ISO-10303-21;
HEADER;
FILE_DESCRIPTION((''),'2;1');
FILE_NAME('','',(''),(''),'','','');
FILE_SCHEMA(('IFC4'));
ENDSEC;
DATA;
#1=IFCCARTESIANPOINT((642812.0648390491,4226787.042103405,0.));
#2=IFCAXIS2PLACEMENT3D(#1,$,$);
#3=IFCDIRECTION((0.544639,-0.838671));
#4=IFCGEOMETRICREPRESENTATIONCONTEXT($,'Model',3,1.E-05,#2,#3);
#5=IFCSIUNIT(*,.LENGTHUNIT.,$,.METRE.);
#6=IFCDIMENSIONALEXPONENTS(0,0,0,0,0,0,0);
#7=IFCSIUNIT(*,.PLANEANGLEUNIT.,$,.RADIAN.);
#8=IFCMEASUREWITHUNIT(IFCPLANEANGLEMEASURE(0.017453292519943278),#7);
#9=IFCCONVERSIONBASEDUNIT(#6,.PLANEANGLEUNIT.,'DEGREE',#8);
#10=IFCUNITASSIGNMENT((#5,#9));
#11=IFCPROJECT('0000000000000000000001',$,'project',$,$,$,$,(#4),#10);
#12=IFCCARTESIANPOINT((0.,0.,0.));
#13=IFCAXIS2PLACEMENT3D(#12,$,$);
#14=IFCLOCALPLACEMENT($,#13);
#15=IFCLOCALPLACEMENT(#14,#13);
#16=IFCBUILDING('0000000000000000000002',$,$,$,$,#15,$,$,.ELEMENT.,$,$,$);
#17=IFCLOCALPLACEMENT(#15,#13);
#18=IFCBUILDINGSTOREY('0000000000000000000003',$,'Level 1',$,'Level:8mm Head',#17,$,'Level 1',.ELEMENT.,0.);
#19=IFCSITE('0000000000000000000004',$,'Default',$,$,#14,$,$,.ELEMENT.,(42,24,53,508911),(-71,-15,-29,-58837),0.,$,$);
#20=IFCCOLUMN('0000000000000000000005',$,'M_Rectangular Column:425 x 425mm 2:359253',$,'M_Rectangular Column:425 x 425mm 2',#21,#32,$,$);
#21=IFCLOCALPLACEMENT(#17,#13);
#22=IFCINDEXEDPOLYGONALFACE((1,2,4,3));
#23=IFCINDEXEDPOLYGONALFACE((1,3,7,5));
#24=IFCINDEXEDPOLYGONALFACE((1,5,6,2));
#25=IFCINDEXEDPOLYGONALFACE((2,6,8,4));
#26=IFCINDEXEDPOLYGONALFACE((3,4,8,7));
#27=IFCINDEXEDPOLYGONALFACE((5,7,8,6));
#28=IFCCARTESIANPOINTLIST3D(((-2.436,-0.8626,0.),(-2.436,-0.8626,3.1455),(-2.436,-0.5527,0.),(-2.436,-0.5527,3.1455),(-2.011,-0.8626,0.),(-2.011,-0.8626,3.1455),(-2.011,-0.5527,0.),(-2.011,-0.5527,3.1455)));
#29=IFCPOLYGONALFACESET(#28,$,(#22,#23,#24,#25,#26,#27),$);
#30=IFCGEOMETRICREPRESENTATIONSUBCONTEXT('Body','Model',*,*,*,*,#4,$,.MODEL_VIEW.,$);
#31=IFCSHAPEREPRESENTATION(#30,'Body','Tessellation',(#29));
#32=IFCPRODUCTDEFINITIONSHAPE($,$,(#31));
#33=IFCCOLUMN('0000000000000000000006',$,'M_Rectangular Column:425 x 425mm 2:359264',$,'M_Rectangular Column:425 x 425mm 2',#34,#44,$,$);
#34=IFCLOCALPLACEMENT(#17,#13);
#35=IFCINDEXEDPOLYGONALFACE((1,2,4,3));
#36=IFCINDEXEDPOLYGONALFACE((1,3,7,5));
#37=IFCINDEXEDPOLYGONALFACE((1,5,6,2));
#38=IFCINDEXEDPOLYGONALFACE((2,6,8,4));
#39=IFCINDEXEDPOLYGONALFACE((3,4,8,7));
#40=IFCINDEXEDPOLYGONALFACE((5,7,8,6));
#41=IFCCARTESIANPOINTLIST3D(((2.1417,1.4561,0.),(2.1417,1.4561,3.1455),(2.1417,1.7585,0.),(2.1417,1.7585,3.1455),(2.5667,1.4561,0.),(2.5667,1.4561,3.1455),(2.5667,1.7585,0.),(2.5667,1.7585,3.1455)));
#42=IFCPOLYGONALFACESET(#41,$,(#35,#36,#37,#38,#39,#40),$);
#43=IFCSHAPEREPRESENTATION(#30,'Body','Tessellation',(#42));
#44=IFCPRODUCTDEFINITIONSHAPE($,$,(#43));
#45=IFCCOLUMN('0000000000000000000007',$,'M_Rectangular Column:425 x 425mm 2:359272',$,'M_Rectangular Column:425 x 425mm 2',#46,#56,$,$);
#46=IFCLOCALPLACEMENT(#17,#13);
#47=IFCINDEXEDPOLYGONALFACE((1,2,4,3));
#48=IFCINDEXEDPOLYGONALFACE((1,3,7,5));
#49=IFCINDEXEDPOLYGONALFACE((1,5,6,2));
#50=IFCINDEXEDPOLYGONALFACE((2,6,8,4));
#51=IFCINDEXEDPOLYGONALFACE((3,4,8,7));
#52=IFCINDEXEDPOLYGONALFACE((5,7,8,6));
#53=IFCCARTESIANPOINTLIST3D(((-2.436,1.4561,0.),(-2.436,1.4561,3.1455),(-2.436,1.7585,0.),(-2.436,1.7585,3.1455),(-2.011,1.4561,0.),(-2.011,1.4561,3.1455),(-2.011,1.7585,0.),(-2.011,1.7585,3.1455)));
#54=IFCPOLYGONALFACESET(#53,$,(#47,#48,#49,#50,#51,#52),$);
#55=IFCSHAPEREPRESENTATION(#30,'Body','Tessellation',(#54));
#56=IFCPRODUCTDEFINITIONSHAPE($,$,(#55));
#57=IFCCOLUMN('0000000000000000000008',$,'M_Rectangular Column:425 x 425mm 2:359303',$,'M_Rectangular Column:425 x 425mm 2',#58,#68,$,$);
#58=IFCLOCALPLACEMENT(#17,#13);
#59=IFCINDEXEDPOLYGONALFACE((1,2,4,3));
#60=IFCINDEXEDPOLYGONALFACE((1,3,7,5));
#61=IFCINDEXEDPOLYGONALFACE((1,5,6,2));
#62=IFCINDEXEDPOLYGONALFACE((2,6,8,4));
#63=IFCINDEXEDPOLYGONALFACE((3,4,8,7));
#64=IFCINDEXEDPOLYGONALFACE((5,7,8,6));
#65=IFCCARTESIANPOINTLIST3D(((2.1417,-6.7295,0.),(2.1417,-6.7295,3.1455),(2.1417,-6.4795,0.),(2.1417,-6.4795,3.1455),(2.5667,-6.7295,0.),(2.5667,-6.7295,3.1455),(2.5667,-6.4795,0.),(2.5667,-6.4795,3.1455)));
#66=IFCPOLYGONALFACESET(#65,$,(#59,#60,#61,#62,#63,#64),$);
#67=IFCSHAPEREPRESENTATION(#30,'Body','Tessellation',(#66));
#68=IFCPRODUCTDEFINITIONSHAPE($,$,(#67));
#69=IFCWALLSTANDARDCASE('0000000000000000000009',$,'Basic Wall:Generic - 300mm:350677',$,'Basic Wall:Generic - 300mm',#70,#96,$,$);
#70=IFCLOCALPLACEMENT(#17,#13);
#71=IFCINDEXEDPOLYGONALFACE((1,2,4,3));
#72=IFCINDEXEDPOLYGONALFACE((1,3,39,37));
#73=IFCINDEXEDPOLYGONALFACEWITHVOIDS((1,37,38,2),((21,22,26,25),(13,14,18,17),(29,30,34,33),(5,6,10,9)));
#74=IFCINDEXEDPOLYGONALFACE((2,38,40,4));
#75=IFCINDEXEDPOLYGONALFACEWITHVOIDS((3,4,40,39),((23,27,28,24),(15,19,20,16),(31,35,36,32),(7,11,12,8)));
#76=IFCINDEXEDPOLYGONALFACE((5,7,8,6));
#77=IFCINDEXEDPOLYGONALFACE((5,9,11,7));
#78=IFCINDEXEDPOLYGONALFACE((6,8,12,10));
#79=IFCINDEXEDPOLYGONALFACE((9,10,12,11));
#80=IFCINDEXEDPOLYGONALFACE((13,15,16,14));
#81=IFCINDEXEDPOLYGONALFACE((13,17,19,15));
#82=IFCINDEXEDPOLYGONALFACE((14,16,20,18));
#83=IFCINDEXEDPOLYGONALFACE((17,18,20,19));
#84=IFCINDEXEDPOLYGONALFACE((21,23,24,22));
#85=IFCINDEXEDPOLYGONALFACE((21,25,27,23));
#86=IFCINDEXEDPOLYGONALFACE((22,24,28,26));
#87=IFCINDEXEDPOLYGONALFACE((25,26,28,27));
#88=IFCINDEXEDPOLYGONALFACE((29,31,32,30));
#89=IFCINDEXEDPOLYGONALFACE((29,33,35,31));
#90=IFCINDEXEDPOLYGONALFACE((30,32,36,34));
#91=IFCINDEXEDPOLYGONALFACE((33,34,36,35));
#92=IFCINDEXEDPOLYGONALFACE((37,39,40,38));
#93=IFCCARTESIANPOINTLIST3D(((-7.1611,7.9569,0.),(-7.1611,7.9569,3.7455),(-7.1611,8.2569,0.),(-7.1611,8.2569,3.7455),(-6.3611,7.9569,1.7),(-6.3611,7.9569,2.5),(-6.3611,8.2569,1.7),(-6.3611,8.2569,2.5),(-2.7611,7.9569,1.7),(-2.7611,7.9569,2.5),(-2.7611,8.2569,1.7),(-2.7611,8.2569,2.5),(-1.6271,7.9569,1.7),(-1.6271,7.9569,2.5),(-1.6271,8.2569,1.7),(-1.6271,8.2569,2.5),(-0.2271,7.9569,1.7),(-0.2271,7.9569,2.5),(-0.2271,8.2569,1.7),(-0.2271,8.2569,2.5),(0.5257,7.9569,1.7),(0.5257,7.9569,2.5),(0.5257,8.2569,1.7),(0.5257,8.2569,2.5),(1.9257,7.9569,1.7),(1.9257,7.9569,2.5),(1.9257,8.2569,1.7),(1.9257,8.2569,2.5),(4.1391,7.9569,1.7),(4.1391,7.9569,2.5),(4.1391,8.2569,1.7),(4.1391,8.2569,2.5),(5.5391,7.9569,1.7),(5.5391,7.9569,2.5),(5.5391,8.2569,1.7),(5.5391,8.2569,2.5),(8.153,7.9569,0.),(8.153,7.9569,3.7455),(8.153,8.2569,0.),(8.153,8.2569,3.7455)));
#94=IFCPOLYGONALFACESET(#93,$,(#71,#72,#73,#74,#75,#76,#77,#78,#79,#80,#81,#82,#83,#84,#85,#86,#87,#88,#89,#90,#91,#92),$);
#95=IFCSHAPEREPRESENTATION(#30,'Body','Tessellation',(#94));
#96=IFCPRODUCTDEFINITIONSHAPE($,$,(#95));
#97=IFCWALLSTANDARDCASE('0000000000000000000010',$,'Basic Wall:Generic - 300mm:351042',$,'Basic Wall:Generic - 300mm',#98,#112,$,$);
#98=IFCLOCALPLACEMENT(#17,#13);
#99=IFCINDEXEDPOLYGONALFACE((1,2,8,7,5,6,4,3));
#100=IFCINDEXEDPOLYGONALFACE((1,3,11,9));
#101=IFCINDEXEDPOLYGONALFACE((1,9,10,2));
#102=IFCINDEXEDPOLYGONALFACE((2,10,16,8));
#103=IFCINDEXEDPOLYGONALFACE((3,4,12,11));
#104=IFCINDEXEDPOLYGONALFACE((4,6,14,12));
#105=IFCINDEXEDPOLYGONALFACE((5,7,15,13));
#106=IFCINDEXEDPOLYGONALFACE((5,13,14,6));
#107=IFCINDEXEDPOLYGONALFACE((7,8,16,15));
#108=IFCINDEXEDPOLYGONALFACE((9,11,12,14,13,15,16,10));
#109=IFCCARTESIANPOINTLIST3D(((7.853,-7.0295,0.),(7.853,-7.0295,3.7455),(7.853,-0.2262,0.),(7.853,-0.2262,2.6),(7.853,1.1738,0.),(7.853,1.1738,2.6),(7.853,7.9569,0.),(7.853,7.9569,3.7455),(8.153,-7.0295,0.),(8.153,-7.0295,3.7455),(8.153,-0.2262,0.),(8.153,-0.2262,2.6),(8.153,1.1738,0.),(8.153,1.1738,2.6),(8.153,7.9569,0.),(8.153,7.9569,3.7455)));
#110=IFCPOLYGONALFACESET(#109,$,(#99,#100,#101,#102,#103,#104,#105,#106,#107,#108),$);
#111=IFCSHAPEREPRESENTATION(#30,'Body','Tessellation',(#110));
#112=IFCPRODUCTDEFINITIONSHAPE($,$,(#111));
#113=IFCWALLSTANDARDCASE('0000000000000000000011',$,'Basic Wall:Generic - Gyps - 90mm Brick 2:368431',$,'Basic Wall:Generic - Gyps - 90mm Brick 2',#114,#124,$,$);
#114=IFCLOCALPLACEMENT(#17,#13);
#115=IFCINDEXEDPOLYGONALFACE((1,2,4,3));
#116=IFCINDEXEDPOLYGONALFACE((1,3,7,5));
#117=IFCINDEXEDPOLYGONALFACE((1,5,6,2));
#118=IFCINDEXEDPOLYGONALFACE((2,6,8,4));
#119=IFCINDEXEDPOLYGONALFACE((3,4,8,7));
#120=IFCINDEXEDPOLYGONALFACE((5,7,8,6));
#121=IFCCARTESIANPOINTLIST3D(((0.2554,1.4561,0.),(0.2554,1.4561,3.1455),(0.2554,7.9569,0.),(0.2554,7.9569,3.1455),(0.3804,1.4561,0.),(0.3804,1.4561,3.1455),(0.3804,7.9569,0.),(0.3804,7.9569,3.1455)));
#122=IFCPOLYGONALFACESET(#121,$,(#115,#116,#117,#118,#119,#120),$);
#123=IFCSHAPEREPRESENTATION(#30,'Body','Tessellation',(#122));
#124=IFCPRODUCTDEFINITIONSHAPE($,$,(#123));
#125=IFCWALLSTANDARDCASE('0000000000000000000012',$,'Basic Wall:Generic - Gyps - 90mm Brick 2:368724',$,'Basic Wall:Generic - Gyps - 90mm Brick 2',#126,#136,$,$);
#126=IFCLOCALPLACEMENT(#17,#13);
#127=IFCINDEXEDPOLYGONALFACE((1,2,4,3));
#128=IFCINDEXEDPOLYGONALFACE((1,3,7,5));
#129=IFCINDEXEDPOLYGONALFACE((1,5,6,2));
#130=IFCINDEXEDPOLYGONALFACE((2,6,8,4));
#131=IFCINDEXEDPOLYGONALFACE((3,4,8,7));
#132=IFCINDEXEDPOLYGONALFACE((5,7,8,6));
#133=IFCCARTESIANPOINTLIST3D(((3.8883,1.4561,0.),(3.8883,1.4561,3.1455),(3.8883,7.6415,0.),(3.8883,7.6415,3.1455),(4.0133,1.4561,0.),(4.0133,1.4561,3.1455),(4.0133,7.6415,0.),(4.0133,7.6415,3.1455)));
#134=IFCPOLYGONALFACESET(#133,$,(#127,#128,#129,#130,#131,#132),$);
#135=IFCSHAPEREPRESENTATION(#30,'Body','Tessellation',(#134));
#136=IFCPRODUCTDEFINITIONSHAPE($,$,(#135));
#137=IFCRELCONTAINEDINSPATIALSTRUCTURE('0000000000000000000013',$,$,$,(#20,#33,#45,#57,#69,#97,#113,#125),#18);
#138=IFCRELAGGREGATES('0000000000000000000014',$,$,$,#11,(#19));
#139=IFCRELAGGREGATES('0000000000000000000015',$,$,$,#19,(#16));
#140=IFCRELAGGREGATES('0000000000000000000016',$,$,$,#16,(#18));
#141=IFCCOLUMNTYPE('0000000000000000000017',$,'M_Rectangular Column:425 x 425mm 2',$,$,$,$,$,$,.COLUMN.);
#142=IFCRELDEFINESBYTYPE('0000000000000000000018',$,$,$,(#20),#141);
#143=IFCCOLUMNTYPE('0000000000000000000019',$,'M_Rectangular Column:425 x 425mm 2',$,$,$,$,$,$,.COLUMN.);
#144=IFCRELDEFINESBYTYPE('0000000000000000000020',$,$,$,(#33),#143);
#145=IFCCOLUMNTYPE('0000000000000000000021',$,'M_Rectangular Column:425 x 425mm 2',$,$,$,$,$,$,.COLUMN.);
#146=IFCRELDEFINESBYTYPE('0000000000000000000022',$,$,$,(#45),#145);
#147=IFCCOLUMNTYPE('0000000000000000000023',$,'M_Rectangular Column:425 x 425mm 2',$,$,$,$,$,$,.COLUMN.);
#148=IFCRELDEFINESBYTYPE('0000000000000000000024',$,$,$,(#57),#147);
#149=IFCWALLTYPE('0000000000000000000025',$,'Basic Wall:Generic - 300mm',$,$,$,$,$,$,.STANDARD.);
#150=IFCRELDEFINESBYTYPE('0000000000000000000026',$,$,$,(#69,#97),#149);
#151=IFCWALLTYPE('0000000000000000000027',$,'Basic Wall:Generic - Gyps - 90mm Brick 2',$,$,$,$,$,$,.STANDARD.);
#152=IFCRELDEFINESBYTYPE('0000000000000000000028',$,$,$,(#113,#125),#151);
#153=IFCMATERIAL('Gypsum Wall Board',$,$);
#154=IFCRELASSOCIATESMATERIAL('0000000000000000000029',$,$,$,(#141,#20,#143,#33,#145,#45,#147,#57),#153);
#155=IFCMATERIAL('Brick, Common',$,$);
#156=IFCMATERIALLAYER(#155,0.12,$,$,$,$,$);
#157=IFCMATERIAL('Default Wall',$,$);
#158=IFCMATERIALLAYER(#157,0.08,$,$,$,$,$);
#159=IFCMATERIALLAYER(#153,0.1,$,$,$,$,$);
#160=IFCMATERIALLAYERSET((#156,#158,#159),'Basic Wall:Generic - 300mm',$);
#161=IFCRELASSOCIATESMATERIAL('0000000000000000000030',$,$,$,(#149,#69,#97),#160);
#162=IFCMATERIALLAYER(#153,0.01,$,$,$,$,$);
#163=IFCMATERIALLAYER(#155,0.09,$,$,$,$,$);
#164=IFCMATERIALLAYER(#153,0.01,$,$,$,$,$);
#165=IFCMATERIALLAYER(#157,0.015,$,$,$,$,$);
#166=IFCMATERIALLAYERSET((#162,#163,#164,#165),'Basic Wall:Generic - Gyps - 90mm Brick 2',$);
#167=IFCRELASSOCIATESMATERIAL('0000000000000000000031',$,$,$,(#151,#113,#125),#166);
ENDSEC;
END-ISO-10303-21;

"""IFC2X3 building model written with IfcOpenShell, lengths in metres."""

from ifc_helpers import new_model, entity, si_unit, converted_unit, direction, frame, frame_2d, origin, place, context, subcontext, project, spatial, polyline, rectangle, extrude, clip, halfspace, bounded_halfspace, source, transform, mapped, material, layer, layer_set, layer_usage, type_object, type_shapes, element, save


model = new_model("IFC2X3")

# Units and contexts
model_context = context("Model", 3, precision=1e-05, world=frame((642812.0648390491, 4226787.042103405, 0.0)), true_north=direction((0.544639, -0.838671)))
body_context = subcontext(model_context, "Body", "Model", "MODEL_VIEW")
ifc_project = project(units=[si_unit("LENGTHUNIT", "METRE"), converted_unit("PLANEANGLEUNIT", "DEGREE", entity("IfcPlaneAngleMeasure", 0.017453292519943278), si_unit("PLANEANGLEUNIT", "RADIAN"), dimensions=[0, 0, 0, 0, 0, 0, 0])], contexts=[model_context])

# Site, building, storey
site_placement = place(None, origin())
site = spatial("IfcSite", under=ifc_project, at=site_placement, Name="Default", CompositionType="ELEMENT", RefLatitude=(42, 24, 53, 508911), RefLongitude=(-71, -15, -29, -58837), RefElevation=0.0)
building_placement = place(site_placement, origin())
building = spatial("IfcBuilding", under=site, at=building_placement, CompositionType="ELEMENT")
storey_placement = place(building_placement, origin())
storey = spatial("IfcBuildingStorey", under=building, at=storey_placement, Name="Level 1", ObjectType="Level:8mm Head", LongName="Level 1", CompositionType="ELEMENT", Elevation=0.0)

# Columns
ifc_material_1 = material(Name="Gypsum Wall Board")
column_type_1 = type_object("IfcColumnType", Name="M_Rectangular Column:425 x 425mm 2", PredefinedType="COLUMN", material=ifc_material_1)
shared_shape_1 = source(origin(), body_context, "Body", "SweptSolid", [
    extrude(rectangle(XDim=0.3099, YDim=0.425, at=frame_2d((0.0, 0.0), x_axis=(1.0, 0.0))), frame((-2.2235, -0.7076, 0.0), z_axis=(0.0, 0.0, 1.0), x_axis=(0.0, 1.0, 0.0)), (0.0, 0.0, 1.0), 3.1455),
])
type_shapes(column_type_1, [shared_shape_1])
column_1_placement = place(storey_placement, origin())
element("IfcColumn", 1, at=column_1_placement, inside=storey, type_object=column_type_1, material=ifc_material_1, Name="M_Rectangular Column:425 x 425mm 2:359253", ObjectType="M_Rectangular Column:425 x 425mm 2", context=body_context, shape_type="MappedRepresentation", body=[
    mapped(shared_shape_1, transform((0.0, 0.0, 0.0), scale=1.0)),
])
column_type_2 = type_object("IfcColumnType", Name="M_Rectangular Column:425 x 425mm 2", PredefinedType="COLUMN", material=ifc_material_1)
shared_shape_2 = source(origin(), body_context, "Body", "SweptSolid", [
    extrude(rectangle(XDim=0.3024, YDim=0.425, at=frame_2d((0.0, 0.0), x_axis=(1.0, 0.0))), frame((2.3542, 1.6073, 0.0), z_axis=(0.0, 0.0, 1.0), x_axis=(0.0, -1.0, 0.0)), (0.0, 0.0, 1.0), 3.1455),
])
type_shapes(column_type_2, [shared_shape_2])
column_2_placement = place(storey_placement, origin())
element("IfcColumn", 2, at=column_2_placement, inside=storey, type_object=column_type_2, material=ifc_material_1, Name="M_Rectangular Column:425 x 425mm 2:359264", ObjectType="M_Rectangular Column:425 x 425mm 2", context=body_context, shape_type="MappedRepresentation", body=[
    mapped(shared_shape_2, transform((0.0, 0.0, 0.0), scale=1.0)),
])
column_type_3 = type_object("IfcColumnType", Name="M_Rectangular Column:425 x 425mm 2", PredefinedType="COLUMN", material=ifc_material_1)
shared_shape_3 = source(origin(), body_context, "Body", "SweptSolid", [
    extrude(rectangle(XDim=0.3024, YDim=0.425, at=frame_2d((0.0, 0.0), x_axis=(1.0, 0.0))), frame((-2.2235, 1.6073, 0.0), z_axis=(0.0, 0.0, 1.0), x_axis=(0.0, -1.0, 0.0)), (0.0, 0.0, 1.0), 3.1455),
])
type_shapes(column_type_3, [shared_shape_3])
column_3_placement = place(storey_placement, origin())
element("IfcColumn", 3, at=column_3_placement, inside=storey, type_object=column_type_3, material=ifc_material_1, Name="M_Rectangular Column:425 x 425mm 2:359272", ObjectType="M_Rectangular Column:425 x 425mm 2", context=body_context, shape_type="MappedRepresentation", body=[
    mapped(shared_shape_3, transform((0.0, 0.0, 0.0), scale=1.0)),
])
column_type_4 = type_object("IfcColumnType", Name="M_Rectangular Column:425 x 425mm 2", PredefinedType="COLUMN", material=ifc_material_1)
shared_shape_4 = source(origin(), body_context, "Body", "SweptSolid", [
    extrude(rectangle(XDim=0.25, YDim=0.425, at=frame_2d((0.0, 0.0), x_axis=(1.0, 0.0))), frame((2.3542, -6.6045, 0.0), z_axis=(0.0, 0.0, 1.0), x_axis=(0.0, -1.0, 0.0)), (0.0, 0.0, 1.0), 3.1455),
])
type_shapes(column_type_4, [shared_shape_4])
column_4_placement = place(storey_placement, origin())
element("IfcColumn", 4, at=column_4_placement, inside=storey, type_object=column_type_4, material=ifc_material_1, Name="M_Rectangular Column:425 x 425mm 2:359303", ObjectType="M_Rectangular Column:425 x 425mm 2", context=body_context, shape_type="MappedRepresentation", body=[
    mapped(shared_shape_4, transform((0.0, 0.0, 0.0), scale=1.0)),
])

# Walls, openings
ifc_material_2 = material(Name="Brick, Common")
ifc_layer_1 = layer(ifc_material_2, 0.12)
ifc_material_3 = material(Name="Default Wall")
ifc_layer_2 = layer(ifc_material_3, 0.08)
ifc_layer_3 = layer(ifc_material_1, 0.1)
ifc_layer_set_1 = layer_set([ifc_layer_1, ifc_layer_2, ifc_layer_3], Name="Basic Wall:Generic - 300mm")
ifc_layer_usage_1 = layer_usage(ifc_layer_set_1, "AXIS2", "POSITIVE", -0.15)
wall_type_1 = type_object("IfcWallType", Name="Basic Wall:Generic - 300mm", PredefinedType="STANDARD", material=ifc_layer_set_1)
wall_1_placement = place(storey_placement, frame((8.153, 8.1069, 0.0), z_axis=(0.0, 0.0, 1.0), x_axis=(-1.0, 0.0, 0.0)))
wall_1 = element("IfcWallStandardCase", 5, at=wall_1_placement, inside=storey, type_object=wall_type_1, material=ifc_layer_usage_1, Name="Basic Wall:Generic - 300mm:350677", ObjectType="Basic Wall:Generic - 300mm", context=body_context, shape_type="Clipping", body=[
    clip(extrude(rectangle(XDim=15.314, YDim=0.3, at=frame_2d((7.657, 0.0), x_axis=(-1.0, 0.0))), origin(), (0.0, 0.0, 1.0), 3.7455), halfspace(origin(), True)),
])
opening_1_placement = place(wall_1_placement, frame((14.514, 0.15, 1.7)))
element("IfcOpeningElement", 6, at=opening_1_placement, cuts=wall_1, ObjectType="Opening", context=body_context, shape_type="SweptSolid", body=[
    extrude(rectangle(XDim=0.8, YDim=3.6, at=frame_2d((0.4, 1.8), x_axis=(-1.0, 0.0))), frame((0.0, 0.0, 0.0), z_axis=(0.0, -1.0, 0.0), x_axis=(0.0, 0.0, 1.0)), (0.0, 0.0, 1.0), 0.3),
])
opening_2_placement = place(wall_1_placement, frame((9.7801, 0.15, 1.7)))
element("IfcOpeningElement", 7, at=opening_2_placement, cuts=wall_1, ObjectType="Opening", context=body_context, shape_type="SweptSolid", body=[
    extrude(rectangle(XDim=0.8, YDim=1.4, at=frame_2d((0.4, 0.7), x_axis=(-1.0, 0.0))), frame((0.0, 0.0, 0.0), z_axis=(0.0, -1.0, 0.0), x_axis=(0.0, 0.0, 1.0)), (0.0, 0.0, 1.0), 0.3),
])
opening_3_placement = place(wall_1_placement, frame((7.6272, 0.15, 1.7)))
element("IfcOpeningElement", 8, at=opening_3_placement, cuts=wall_1, ObjectType="Opening", context=body_context, shape_type="SweptSolid", body=[
    extrude(rectangle(XDim=0.8, YDim=1.4, at=frame_2d((0.4, 0.7), x_axis=(-1.0, 0.0))), frame((0.0, 0.0, 0.0), z_axis=(0.0, -1.0, 0.0), x_axis=(0.0, 0.0, 1.0)), (0.0, 0.0, 1.0), 0.3),
])
opening_4_placement = place(wall_1_placement, frame((4.0138, 0.15, 1.7)))
element("IfcOpeningElement", 9, at=opening_4_placement, cuts=wall_1, ObjectType="Opening", context=body_context, shape_type="SweptSolid", body=[
    extrude(rectangle(XDim=0.8, YDim=1.4, at=frame_2d((0.4, 0.7), x_axis=(-1.0, 0.0))), frame((0.0, 0.0, 0.0), z_axis=(0.0, -1.0, 0.0), x_axis=(0.0, 0.0, 1.0)), (0.0, 0.0, 1.0), 0.3),
])
wall_2_placement = place(storey_placement, frame((8.003, -7.0295, 0.0), z_axis=(0.0, 0.0, 1.0), x_axis=(0.0, 1.0, 0.0)))
wall_2 = element("IfcWallStandardCase", 10, at=wall_2_placement, inside=storey, type_object=wall_type_1, material=ifc_layer_usage_1, Name="Basic Wall:Generic - 300mm:351042", ObjectType="Basic Wall:Generic - 300mm", context=body_context, shape_type="Clipping", body=[
    clip(extrude(rectangle(XDim=14.9864, YDim=0.3, at=frame_2d((7.4932, 0.0), x_axis=(1.0, 0.0))), origin(), (0.0, 0.0, 1.0), 3.7455), halfspace(origin(), True)),
])
opening_5_placement = place(wall_2_placement, frame((8.2033, 0.15, 0.0)))
element("IfcOpeningElement", 11, at=opening_5_placement, cuts=wall_2, ObjectType="Opening", context=body_context, shape_type="SweptSolid", body=[
    extrude(rectangle(XDim=2.6, YDim=1.4, at=frame_2d((1.3, 0.7), x_axis=(1.0, 0.0))), frame((0.0, 0.0, 0.0), z_axis=(0.0, -1.0, 0.0), x_axis=(0.0, 0.0, 1.0)), (0.0, 0.0, 1.0), 0.3),
])
opening_6_placement = place(wall_2_placement, frame((8.2033, 0.15, 3.7515)))
element("IfcOpeningElement", 12, at=opening_6_placement, cuts=wall_2, ObjectType="Opening", context=body_context, shape_type="SweptSolid", body=[
    extrude(rectangle(XDim=2.6, YDim=1.4, at=frame_2d((1.3, 0.7), x_axis=(1.0, 0.0))), frame((0.0, 0.0, 0.0), z_axis=(0.0, -1.0, 0.0), x_axis=(0.0, 0.0, 1.0)), (0.0, 0.0, 1.0), 0.3),
])

# Walls
ifc_layer_4 = layer(ifc_material_1, 0.01)
ifc_layer_5 = layer(ifc_material_2, 0.09)
ifc_layer_6 = layer(ifc_material_1, 0.01)
ifc_layer_7 = layer(ifc_material_3, 0.015)
ifc_layer_set_2 = layer_set([ifc_layer_4, ifc_layer_5, ifc_layer_6, ifc_layer_7], Name="Basic Wall:Generic - Gyps - 90mm Brick 2")
ifc_layer_usage_2 = layer_usage(ifc_layer_set_2, "AXIS2", "NEGATIVE", 0.0625)
wall_type_2 = type_object("IfcWallType", Name="Basic Wall:Generic - Gyps - 90mm Brick 2", PredefinedType="STANDARD", material=ifc_layer_set_2)
wall_3_placement = place(storey_placement, frame((0.3179, 7.9569, 0.0), z_axis=(0.0, 0.0, 1.0), x_axis=(0.0, -1.0, 0.0)))
element("IfcWallStandardCase", 13, at=wall_3_placement, inside=storey, type_object=wall_type_2, material=ifc_layer_usage_2, Name="Basic Wall:Generic - Gyps - 90mm Brick 2:368431", ObjectType="Basic Wall:Generic - Gyps - 90mm Brick 2", context=body_context, shape_type="Clipping", body=[
    clip(extrude(rectangle(XDim=6.5009, YDim=0.125, at=frame_2d((3.2504, 0.0), x_axis=(-1.0, 0.0))), origin(), (0.0, 0.0, 1.0), 3.1455), bounded_halfspace(frame((0.0, -0.0625, 3.1455), z_axis=(0.0, 0.0, -1.0), x_axis=(0.0, 1.0, 0.0)), True, frame((0.0, -0.0625, 3.1455)), polyline([(0.0, 0.0), (6.5009, 0.0), (6.5009, 0.125), (0.0, 0.125), (0.0, 0.0)]))),
])
wall_4_placement = place(storey_placement, frame((3.9508, 7.6415, 0.0), z_axis=(0.0, 0.0, 1.0), x_axis=(0.0, -1.0, 0.0)))
element("IfcWallStandardCase", 14, at=wall_4_placement, inside=storey, type_object=wall_type_2, material=ifc_layer_usage_2, Name="Basic Wall:Generic - Gyps - 90mm Brick 2:368724", ObjectType="Basic Wall:Generic - Gyps - 90mm Brick 2", context=body_context, shape_type="Clipping", body=[
    clip(extrude(rectangle(XDim=6.1854, YDim=0.125, at=frame_2d((3.0927, 0.0), x_axis=(-1.0, 0.0))), origin(), (0.0, 0.0, 1.0), 3.1455), bounded_halfspace(frame((0.0, -0.0625, 3.1455), z_axis=(0.0, 0.0, -1.0), x_axis=(0.0, 1.0, 0.0)), True, frame((0.0, -0.0625, 3.1455)), polyline([(0.0, 0.0), (6.1854, 0.0), (6.1854, 0.125), (0.0, 0.125), (0.0, 0.0)]))),
])

save(model, "model.ifc")
